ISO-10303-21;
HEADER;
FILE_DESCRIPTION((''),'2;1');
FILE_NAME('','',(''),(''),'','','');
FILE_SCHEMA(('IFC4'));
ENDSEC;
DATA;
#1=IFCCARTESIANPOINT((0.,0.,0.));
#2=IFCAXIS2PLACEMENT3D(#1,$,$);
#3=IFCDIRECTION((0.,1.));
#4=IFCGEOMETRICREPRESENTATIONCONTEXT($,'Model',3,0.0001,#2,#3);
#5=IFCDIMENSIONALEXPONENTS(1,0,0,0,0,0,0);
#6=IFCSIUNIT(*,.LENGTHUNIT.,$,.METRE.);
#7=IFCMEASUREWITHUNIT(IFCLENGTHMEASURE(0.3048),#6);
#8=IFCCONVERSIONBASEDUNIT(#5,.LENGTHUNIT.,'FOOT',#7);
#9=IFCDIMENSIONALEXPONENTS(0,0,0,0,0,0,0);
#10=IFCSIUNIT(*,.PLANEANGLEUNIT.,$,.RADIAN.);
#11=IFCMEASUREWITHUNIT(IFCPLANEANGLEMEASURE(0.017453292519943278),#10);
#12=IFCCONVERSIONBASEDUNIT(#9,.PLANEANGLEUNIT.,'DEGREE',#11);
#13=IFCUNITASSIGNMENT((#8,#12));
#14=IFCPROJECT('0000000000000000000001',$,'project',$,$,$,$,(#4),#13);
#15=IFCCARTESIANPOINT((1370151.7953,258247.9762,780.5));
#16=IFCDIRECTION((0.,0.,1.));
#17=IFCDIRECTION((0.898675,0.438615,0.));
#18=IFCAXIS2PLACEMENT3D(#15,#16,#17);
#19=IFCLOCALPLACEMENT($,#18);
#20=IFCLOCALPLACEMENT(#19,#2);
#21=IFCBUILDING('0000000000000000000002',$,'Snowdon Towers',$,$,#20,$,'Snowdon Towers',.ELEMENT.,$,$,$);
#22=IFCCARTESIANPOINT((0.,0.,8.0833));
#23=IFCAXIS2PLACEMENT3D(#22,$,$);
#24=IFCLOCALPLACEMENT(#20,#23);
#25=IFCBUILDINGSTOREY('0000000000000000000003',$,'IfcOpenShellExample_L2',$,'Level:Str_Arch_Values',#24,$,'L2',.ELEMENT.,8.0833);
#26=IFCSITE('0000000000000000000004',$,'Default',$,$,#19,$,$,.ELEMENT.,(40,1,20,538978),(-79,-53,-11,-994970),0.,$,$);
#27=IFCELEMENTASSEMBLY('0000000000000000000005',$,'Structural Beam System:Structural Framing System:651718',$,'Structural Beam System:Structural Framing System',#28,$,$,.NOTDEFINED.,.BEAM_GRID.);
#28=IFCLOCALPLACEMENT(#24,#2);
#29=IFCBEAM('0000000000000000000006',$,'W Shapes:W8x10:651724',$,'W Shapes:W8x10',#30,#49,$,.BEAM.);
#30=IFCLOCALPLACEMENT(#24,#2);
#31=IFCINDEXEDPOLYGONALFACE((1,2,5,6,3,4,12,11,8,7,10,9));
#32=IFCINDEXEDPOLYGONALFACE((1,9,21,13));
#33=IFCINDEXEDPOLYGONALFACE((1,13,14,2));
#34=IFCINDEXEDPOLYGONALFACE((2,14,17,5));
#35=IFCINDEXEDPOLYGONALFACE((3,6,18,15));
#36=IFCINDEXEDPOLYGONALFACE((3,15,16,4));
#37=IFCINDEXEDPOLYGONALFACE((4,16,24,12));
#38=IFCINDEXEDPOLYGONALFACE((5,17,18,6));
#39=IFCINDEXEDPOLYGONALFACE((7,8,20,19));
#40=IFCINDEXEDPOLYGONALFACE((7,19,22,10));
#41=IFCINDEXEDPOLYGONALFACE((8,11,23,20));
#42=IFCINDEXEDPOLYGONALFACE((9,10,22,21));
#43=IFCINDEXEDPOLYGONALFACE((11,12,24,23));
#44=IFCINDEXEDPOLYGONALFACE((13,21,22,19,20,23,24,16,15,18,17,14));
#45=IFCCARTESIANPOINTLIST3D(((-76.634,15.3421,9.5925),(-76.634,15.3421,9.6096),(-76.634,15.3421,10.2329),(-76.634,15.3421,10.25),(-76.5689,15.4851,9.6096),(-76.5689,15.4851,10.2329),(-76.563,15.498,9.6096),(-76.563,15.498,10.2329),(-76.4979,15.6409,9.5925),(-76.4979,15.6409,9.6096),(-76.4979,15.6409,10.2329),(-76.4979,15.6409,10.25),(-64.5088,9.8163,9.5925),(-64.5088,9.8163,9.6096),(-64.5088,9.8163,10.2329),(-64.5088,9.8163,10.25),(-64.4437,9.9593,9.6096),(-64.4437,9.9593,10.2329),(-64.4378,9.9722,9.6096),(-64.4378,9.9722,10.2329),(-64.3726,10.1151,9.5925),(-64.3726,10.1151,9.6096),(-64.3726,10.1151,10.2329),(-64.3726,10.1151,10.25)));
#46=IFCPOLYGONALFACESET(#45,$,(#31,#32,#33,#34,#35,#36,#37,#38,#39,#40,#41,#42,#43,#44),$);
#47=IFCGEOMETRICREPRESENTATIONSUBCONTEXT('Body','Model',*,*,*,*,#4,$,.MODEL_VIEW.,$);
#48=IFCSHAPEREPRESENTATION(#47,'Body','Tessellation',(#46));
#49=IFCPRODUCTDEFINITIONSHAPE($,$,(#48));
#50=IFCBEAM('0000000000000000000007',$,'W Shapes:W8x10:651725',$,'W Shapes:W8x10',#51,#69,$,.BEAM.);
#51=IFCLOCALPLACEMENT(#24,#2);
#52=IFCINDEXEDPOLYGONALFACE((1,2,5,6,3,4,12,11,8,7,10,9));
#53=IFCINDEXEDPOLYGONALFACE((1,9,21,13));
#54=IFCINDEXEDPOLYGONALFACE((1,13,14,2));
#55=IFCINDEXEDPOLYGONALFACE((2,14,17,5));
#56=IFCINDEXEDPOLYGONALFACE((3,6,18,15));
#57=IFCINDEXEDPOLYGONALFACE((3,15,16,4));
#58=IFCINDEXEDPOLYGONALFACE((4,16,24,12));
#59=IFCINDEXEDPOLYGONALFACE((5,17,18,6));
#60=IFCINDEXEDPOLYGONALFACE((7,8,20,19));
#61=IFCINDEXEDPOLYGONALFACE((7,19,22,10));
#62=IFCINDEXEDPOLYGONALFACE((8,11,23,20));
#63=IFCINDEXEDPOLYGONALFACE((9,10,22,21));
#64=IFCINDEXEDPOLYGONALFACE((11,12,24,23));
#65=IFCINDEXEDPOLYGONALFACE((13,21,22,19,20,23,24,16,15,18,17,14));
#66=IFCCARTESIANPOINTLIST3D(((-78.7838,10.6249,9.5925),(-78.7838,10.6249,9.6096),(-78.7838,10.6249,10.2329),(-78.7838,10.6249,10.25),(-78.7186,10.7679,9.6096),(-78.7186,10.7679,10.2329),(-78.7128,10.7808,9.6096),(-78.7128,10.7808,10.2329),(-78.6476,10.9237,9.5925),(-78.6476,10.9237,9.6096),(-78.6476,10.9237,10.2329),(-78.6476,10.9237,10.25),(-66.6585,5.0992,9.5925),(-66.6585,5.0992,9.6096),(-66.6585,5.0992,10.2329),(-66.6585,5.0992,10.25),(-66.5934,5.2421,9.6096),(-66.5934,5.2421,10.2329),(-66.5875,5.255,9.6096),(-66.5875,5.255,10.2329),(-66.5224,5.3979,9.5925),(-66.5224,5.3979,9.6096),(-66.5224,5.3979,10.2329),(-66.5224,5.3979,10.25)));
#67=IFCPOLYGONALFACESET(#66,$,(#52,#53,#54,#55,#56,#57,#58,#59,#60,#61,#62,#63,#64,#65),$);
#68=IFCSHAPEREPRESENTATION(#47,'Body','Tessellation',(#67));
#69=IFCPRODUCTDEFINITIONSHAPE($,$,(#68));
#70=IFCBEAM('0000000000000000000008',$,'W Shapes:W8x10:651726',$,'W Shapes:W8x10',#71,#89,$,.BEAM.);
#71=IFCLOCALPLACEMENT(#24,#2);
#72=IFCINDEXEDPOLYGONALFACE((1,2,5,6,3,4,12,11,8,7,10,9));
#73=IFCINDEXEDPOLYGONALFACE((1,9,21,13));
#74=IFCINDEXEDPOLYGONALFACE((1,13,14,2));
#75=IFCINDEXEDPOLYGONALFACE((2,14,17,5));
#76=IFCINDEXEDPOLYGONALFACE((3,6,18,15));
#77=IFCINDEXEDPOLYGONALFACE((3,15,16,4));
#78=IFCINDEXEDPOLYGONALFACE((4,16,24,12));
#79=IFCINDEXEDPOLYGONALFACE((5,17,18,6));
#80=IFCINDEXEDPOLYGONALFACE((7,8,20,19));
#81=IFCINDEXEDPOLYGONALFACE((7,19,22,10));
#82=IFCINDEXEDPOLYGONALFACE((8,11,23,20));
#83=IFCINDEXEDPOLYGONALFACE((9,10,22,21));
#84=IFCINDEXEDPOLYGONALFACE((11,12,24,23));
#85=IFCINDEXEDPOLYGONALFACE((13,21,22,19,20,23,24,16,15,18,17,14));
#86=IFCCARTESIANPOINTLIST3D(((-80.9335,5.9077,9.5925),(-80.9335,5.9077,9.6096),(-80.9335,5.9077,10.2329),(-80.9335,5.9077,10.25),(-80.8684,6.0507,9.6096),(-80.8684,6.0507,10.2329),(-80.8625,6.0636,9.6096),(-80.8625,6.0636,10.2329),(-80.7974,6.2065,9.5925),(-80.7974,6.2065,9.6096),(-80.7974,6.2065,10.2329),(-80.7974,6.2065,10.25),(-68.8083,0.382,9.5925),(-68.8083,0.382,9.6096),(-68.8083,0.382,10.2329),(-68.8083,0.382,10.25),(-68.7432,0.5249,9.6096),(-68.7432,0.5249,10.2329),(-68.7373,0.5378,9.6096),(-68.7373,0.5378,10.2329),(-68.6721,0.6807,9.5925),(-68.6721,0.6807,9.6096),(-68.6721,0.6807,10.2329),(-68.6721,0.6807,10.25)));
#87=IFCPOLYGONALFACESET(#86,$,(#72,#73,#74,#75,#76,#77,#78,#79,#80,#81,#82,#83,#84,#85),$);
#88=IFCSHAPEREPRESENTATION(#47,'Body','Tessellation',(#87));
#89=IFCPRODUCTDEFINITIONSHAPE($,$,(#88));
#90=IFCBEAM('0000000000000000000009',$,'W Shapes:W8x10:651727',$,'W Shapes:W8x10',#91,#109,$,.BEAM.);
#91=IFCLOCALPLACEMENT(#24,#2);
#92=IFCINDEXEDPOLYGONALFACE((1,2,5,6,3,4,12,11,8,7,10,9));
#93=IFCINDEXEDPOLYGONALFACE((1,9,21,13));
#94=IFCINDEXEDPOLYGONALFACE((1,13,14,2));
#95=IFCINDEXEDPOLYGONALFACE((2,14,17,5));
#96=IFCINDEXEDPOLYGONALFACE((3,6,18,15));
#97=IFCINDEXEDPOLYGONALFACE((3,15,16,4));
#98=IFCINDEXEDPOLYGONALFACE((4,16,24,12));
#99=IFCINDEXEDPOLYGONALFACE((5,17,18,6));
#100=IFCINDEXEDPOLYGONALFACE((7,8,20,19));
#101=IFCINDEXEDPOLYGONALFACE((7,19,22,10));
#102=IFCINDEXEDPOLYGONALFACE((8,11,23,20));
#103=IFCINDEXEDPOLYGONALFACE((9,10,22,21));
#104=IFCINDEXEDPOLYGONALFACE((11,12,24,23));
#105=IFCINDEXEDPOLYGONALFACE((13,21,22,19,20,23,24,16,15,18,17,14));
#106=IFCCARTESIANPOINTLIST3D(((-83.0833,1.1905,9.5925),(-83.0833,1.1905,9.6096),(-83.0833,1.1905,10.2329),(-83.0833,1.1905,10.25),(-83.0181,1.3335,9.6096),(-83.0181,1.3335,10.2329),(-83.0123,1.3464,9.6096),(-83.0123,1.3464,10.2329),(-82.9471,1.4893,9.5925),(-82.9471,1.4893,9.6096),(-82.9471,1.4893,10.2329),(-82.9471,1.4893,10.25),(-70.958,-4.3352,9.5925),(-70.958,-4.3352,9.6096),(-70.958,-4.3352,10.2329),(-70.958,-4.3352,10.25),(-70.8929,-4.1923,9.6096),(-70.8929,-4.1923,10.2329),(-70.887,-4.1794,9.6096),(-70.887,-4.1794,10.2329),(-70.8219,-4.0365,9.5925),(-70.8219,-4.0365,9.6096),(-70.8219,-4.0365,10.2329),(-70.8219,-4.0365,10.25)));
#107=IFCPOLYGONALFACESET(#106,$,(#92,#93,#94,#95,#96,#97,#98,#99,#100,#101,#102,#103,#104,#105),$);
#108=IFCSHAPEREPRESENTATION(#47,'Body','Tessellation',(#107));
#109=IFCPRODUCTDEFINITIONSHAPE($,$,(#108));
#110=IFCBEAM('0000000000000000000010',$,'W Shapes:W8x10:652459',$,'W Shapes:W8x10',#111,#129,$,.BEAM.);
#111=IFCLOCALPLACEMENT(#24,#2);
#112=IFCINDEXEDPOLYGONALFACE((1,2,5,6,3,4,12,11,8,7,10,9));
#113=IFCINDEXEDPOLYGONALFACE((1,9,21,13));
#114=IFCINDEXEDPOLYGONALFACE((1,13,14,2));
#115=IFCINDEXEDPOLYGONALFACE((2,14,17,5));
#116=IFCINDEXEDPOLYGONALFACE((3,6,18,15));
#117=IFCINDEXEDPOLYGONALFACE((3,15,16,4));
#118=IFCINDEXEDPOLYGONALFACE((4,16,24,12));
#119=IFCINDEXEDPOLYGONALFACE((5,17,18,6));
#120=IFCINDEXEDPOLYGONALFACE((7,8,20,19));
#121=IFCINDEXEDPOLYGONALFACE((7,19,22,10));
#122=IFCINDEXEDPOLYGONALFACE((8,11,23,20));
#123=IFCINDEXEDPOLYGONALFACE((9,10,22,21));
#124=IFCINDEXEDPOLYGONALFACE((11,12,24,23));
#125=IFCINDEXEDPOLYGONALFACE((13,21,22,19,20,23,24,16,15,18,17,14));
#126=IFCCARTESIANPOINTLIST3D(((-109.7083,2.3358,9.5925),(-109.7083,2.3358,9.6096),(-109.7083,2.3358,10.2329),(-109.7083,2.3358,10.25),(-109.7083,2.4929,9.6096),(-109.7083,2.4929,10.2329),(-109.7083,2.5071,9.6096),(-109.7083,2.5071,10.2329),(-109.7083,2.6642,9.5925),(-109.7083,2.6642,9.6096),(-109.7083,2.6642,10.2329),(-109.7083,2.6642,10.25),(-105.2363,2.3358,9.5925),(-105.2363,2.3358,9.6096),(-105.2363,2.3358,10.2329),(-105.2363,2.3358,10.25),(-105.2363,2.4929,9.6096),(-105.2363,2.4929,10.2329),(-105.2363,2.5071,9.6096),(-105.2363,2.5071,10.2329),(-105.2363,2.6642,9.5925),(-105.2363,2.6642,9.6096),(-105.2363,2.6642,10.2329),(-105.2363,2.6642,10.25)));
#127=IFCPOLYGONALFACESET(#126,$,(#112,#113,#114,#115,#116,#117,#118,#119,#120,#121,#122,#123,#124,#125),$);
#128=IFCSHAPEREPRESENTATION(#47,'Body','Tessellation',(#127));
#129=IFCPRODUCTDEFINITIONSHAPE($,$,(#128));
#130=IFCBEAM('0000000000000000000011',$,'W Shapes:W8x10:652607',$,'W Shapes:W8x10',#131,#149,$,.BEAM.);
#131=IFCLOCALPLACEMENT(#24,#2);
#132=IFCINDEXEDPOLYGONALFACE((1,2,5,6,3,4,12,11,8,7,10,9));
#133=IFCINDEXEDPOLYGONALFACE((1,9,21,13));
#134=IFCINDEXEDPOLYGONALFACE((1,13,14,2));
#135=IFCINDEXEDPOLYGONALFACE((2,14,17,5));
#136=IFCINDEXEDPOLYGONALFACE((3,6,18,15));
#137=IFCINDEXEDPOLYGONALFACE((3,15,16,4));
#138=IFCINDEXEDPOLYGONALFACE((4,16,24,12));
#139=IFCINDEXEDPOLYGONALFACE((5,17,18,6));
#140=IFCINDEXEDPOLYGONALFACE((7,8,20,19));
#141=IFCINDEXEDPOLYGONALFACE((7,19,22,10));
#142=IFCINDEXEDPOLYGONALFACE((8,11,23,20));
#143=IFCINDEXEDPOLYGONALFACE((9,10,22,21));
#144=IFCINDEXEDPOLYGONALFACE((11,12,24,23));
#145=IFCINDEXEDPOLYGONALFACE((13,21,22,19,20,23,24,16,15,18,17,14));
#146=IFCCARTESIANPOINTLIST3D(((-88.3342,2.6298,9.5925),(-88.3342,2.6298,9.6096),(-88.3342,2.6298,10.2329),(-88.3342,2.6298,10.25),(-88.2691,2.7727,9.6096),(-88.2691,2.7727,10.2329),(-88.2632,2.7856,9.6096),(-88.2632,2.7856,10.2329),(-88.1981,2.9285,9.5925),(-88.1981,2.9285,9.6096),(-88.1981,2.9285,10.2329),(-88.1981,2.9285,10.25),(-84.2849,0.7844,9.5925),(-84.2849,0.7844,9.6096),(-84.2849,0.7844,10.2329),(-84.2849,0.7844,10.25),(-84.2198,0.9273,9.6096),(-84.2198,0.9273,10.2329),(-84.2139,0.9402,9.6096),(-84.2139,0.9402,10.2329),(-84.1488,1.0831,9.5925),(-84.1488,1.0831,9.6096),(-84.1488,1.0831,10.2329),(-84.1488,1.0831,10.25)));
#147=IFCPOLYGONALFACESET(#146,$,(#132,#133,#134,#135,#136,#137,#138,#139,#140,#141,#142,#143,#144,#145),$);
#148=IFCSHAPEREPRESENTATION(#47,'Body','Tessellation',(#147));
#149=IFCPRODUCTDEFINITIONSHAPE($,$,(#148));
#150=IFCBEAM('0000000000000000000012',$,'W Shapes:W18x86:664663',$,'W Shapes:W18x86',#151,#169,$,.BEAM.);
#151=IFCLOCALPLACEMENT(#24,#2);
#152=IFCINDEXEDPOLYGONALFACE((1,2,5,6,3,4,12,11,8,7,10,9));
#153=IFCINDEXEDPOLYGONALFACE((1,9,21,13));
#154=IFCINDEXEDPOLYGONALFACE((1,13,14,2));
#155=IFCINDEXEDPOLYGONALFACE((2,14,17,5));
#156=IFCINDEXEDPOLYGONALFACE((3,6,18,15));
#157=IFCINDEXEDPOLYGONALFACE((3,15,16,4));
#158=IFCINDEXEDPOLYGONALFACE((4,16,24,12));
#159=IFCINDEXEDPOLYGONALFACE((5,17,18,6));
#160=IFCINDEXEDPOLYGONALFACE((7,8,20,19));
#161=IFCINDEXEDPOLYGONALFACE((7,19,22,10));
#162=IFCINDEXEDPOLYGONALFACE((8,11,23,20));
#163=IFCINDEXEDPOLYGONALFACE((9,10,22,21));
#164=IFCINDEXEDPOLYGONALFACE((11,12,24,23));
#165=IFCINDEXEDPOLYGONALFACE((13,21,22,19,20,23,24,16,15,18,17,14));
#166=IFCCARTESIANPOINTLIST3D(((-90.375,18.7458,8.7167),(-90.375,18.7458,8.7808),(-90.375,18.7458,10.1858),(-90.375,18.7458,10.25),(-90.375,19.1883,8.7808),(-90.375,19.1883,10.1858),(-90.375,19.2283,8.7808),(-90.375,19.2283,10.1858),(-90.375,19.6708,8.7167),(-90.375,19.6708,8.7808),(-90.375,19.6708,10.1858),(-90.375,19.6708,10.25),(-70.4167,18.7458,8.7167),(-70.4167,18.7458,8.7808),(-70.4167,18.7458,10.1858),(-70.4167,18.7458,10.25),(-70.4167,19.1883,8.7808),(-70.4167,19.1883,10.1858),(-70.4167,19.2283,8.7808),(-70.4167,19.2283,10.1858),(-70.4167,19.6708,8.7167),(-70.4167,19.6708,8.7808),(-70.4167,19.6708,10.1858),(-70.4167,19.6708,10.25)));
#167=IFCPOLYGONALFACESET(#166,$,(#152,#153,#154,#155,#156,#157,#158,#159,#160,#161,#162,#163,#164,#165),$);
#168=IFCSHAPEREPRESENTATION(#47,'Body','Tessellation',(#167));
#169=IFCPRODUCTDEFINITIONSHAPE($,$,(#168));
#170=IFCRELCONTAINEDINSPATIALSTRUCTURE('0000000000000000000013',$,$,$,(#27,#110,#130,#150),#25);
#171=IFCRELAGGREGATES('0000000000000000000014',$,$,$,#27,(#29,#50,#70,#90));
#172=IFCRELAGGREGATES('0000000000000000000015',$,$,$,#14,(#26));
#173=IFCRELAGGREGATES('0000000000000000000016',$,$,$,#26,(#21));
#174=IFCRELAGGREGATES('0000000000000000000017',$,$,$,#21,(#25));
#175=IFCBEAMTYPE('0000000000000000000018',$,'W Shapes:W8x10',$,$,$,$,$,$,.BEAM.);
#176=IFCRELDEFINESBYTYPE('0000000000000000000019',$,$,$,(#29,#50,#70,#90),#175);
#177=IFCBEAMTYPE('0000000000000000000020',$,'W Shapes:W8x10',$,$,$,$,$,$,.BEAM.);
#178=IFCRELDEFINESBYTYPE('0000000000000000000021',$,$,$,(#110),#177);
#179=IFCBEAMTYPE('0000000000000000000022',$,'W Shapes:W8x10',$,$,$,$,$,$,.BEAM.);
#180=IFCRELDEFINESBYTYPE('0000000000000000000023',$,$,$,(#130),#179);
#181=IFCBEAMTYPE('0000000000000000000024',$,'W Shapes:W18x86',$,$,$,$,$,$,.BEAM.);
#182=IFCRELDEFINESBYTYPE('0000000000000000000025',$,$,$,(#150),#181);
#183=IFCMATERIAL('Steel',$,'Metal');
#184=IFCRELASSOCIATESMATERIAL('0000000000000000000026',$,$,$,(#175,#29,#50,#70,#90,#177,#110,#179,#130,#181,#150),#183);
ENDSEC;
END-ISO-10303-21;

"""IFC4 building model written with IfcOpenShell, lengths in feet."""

from ifc_helpers import new_model, entity, si_unit, converted_unit, direction, frame, origin, place, context, subcontext, project, spatial, indexed_curve, outline, extrude, source, transform, mapped, material, type_object, type_shapes, element, aggregate, save


model = new_model("IFC4")

# Units and contexts
model_context = context("Model", 3, precision=0.0001, world=origin(), true_north=direction((0.0, 1.0)))
body_context = subcontext(model_context, "Body", "Model", "MODEL_VIEW")
ifc_project = project(units=[converted_unit("LENGTHUNIT", "FOOT", entity("IfcLengthMeasure", 0.3048), si_unit("LENGTHUNIT", "METRE"), dimensions=[1, 0, 0, 0, 0, 0, 0]), converted_unit("PLANEANGLEUNIT", "DEGREE", entity("IfcPlaneAngleMeasure", 0.017453292519943278), si_unit("PLANEANGLEUNIT", "RADIAN"), dimensions=[0, 0, 0, 0, 0, 0, 0])], contexts=[model_context])

# Site, building, storey
site_placement = place(None, frame((1370151.7953, 258247.9762, 780.5), z_axis=(0.0, 0.0, 1.0), x_axis=(0.898675, 0.438615, 0.0)))
site = spatial("IfcSite", under=ifc_project, at=site_placement, Name="Default", CompositionType="ELEMENT", RefLatitude=(40, 1, 20, 538978), RefLongitude=(-79, -53, -11, -994970), RefElevation=0.0)
building_placement = place(site_placement, origin())
building = spatial("IfcBuilding", under=site, at=building_placement, Name="Snowdon Towers", LongName="Snowdon Towers", CompositionType="ELEMENT")
storey_placement = place(building_placement, frame((0.0, 0.0, 8.0833)))
storey = spatial("IfcBuildingStorey", under=building, at=storey_placement, Name="IfcOpenShellExample_L2", ObjectType="Level:Str_Arch_Values", LongName="L2", CompositionType="ELEMENT", Elevation=8.0833)

# Shared definitions
ifc_material = material(Name="Steel", Category="Metal")

# Element assembly, beams
assembly_1_placement = place(storey_placement, origin())
assembly_1 = element("IfcElementAssembly", 1, at=assembly_1_placement, inside=storey, Name="Structural Beam System:Structural Framing System:651718", ObjectType="Structural Beam System:Structural Framing System", AssemblyPlace="NOTDEFINED", PredefinedType="BEAM_GRID")
beam_type_1 = type_object("IfcBeamType", Name="W Shapes:W8x10", PredefinedType="BEAM", material=ifc_material)
shared_shape_1 = source(origin(), body_context, "Body", "SweptSolid", [
    extrude(outline(indexed_curve([(-0.1642, -0.3117), (-0.1642, -0.3288), (0.1642, -0.3288), (0.1642, -0.3117), (0.0071, -0.3117), (0.0071, 0.3117), (0.1642, 0.3117), (0.1642, 0.3287), (-0.1642, 0.3287), (-0.1642, 0.3117), (-0.0071, 0.3117), (-0.0071, -0.3117), (-0.1642, -0.3117)], self_intersect=False)), frame((-6.6625, 0.0, 0.0), z_axis=(-1.0, 0.0, 0.0), x_axis=(0.0, -1.0, 0.0)), (0.0, 0.0, -1.0), 13.325),
])
type_shapes(beam_type_1, [shared_shape_1])
beam_1_placement = place(assembly_1_placement, frame((-70.5033, 12.7286, 9.9213), z_axis=(0.0, 0.0, 1.0), x_axis=(0.909961, -0.414693, 0.0)))
beam_1 = element("IfcBeam", 2, at=beam_1_placement, type_object=beam_type_1, material=ifc_material, Name="W Shapes:W8x10:651724", ObjectType="W Shapes:W8x10", PredefinedType="BEAM", context=body_context, shape_type="MappedRepresentation", body=[
    mapped(shared_shape_1, transform((0.0, 0.0, 0.0), scale=1.0)),
])
beam_2_placement = place(assembly_1_placement, frame((-72.6531, 8.0114, 9.9213), z_axis=(0.0, 0.0, 1.0), x_axis=(0.909961, -0.414693, 0.0)))
beam_2 = element("IfcBeam", 3, at=beam_2_placement, type_object=beam_type_1, material=ifc_material, Name="W Shapes:W8x10:651725", ObjectType="W Shapes:W8x10", PredefinedType="BEAM", context=body_context, shape_type="MappedRepresentation", body=[
    mapped(shared_shape_1, transform((0.0, 0.0, 0.0), scale=1.0)),
])
beam_3_placement = place(assembly_1_placement, frame((-74.8028, 3.2942, 9.9213), z_axis=(0.0, 0.0, 1.0), x_axis=(0.909961, -0.414693, 0.0)))
beam_3 = element("IfcBeam", 4, at=beam_3_placement, type_object=beam_type_1, material=ifc_material, Name="W Shapes:W8x10:651726", ObjectType="W Shapes:W8x10", PredefinedType="BEAM", context=body_context, shape_type="MappedRepresentation", body=[
    mapped(shared_shape_1, transform((0.0, 0.0, 0.0), scale=1.0)),
])
beam_4_placement = place(assembly_1_placement, frame((-76.9526, -1.423, 9.9213), z_axis=(0.0, 0.0, 1.0), x_axis=(0.909961, -0.414693, 0.0)))
beam_4 = element("IfcBeam", 5, at=beam_4_placement, type_object=beam_type_1, material=ifc_material, Name="W Shapes:W8x10:651727", ObjectType="W Shapes:W8x10", PredefinedType="BEAM", context=body_context, shape_type="MappedRepresentation", body=[
    mapped(shared_shape_1, transform((0.0, 0.0, 0.0), scale=1.0)),
])
aggregate(assembly_1, [beam_1, beam_2, beam_3, beam_4])

# Beams
beam_type_2 = type_object("IfcBeamType", Name="W Shapes:W8x10", PredefinedType="BEAM", material=ifc_material)
shared_shape_2 = source(origin(), body_context, "Body", "SweptSolid", [
    extrude(outline(indexed_curve([(-0.1642, -0.3117), (-0.1642, -0.3288), (0.1642, -0.3288), (0.1642, -0.3117), (0.0071, -0.3117), (0.0071, 0.3117), (0.1642, 0.3117), (0.1642, 0.3287), (-0.1642, 0.3287), (-0.1642, 0.3117), (-0.0071, 0.3117), (-0.0071, -0.3117), (-0.1642, -0.3117)], self_intersect=False)), frame((-1.8817, 0.0, 0.0), z_axis=(-1.0, 0.0, 0.0), x_axis=(0.0, -1.0, 0.0)), (0.0, 0.0, -1.0), 4.472),
])
type_shapes(beam_type_2, [shared_shape_2])
beam_5_placement = place(storey_placement, frame((-107.8266, 2.5, 9.9213)))
element("IfcBeam", 6, at=beam_5_placement, inside=storey, type_object=beam_type_2, material=ifc_material, Name="W Shapes:W8x10:652459", ObjectType="W Shapes:W8x10", PredefinedType="BEAM", context=body_context, shape_type="MappedRepresentation", body=[
    mapped(shared_shape_2, transform((0.0, 0.0, 0.0), scale=1.0)),
])
beam_type_3 = type_object("IfcBeamType", Name="W Shapes:W8x10", PredefinedType="BEAM", material=ifc_material)
shared_shape_3 = source(origin(), body_context, "Body", "SweptSolid", [
    extrude(outline(indexed_curve([(-0.1642, -0.3117), (-0.1642, -0.3288), (0.1642, -0.3288), (0.1642, -0.3117), (0.0071, -0.3117), (0.0071, 0.3117), (0.1642, 0.3117), (0.1642, 0.3287), (-0.1642, 0.3287), (-0.1642, 0.3117), (-0.0071, 0.3117), (-0.0071, -0.3117), (-0.1642, -0.3117)], self_intersect=False)), frame((-2.225, 0.0, 0.0), z_axis=(-1.0, 0.0, 0.0), x_axis=(0.0, -1.0, 0.0)), (0.0, 0.0, -1.0), 4.45),
])
type_shapes(beam_type_3, [shared_shape_3])
beam_6_placement = place(storey_placement, frame((-86.2415, 1.8565, 9.9213), z_axis=(0.0, 0.0, 1.0), x_axis=(-0.909961, 0.414693, 0.0)))
element("IfcBeam", 7, at=beam_6_placement, inside=storey, type_object=beam_type_3, material=ifc_material, Name="W Shapes:W8x10:652607", ObjectType="W Shapes:W8x10", PredefinedType="BEAM", context=body_context, shape_type="MappedRepresentation", body=[
    mapped(shared_shape_3, transform((0.0, 0.0, 0.0), scale=1.0)),
])
beam_type_4 = type_object("IfcBeamType", Name="W Shapes:W18x86", PredefinedType="BEAM", material=ifc_material)
shared_shape_4 = source(origin(), body_context, "Body", "SweptSolid", [
    extrude(outline(indexed_curve([(-0.4625, -0.7025), (-0.4625, -0.7667), (0.4625, -0.7667), (0.4625, -0.7025), (0.02, -0.7025), (0.02, 0.7025), (0.4625, 0.7025), (0.4625, 0.7667), (-0.4625, 0.7667), (-0.4625, 0.7025), (-0.02, 0.7025), (-0.02, -0.7025), (-0.4625, -0.7025)], self_intersect=False)), frame((-10.0, 0.0, 0.0), z_axis=(-1.0, 0.0, 0.0), x_axis=(0.0, -1.0, 0.0)), (0.0, 0.0, -1.0), 19.9583),
])
type_shapes(beam_type_4, [shared_shape_4])
beam_7_placement = place(storey_placement, frame((-80.375, 19.2083, 9.4833)))
element("IfcBeam", 8, at=beam_7_placement, inside=storey, type_object=beam_type_4, material=ifc_material, Name="W Shapes:W18x86:664663", ObjectType="W Shapes:W18x86", PredefinedType="BEAM", context=body_context, shape_type="MappedRepresentation", body=[
    mapped(shared_shape_4, transform((0.0, 0.0, 0.0), scale=1.0)),
])

save(model, "model.ifc")
